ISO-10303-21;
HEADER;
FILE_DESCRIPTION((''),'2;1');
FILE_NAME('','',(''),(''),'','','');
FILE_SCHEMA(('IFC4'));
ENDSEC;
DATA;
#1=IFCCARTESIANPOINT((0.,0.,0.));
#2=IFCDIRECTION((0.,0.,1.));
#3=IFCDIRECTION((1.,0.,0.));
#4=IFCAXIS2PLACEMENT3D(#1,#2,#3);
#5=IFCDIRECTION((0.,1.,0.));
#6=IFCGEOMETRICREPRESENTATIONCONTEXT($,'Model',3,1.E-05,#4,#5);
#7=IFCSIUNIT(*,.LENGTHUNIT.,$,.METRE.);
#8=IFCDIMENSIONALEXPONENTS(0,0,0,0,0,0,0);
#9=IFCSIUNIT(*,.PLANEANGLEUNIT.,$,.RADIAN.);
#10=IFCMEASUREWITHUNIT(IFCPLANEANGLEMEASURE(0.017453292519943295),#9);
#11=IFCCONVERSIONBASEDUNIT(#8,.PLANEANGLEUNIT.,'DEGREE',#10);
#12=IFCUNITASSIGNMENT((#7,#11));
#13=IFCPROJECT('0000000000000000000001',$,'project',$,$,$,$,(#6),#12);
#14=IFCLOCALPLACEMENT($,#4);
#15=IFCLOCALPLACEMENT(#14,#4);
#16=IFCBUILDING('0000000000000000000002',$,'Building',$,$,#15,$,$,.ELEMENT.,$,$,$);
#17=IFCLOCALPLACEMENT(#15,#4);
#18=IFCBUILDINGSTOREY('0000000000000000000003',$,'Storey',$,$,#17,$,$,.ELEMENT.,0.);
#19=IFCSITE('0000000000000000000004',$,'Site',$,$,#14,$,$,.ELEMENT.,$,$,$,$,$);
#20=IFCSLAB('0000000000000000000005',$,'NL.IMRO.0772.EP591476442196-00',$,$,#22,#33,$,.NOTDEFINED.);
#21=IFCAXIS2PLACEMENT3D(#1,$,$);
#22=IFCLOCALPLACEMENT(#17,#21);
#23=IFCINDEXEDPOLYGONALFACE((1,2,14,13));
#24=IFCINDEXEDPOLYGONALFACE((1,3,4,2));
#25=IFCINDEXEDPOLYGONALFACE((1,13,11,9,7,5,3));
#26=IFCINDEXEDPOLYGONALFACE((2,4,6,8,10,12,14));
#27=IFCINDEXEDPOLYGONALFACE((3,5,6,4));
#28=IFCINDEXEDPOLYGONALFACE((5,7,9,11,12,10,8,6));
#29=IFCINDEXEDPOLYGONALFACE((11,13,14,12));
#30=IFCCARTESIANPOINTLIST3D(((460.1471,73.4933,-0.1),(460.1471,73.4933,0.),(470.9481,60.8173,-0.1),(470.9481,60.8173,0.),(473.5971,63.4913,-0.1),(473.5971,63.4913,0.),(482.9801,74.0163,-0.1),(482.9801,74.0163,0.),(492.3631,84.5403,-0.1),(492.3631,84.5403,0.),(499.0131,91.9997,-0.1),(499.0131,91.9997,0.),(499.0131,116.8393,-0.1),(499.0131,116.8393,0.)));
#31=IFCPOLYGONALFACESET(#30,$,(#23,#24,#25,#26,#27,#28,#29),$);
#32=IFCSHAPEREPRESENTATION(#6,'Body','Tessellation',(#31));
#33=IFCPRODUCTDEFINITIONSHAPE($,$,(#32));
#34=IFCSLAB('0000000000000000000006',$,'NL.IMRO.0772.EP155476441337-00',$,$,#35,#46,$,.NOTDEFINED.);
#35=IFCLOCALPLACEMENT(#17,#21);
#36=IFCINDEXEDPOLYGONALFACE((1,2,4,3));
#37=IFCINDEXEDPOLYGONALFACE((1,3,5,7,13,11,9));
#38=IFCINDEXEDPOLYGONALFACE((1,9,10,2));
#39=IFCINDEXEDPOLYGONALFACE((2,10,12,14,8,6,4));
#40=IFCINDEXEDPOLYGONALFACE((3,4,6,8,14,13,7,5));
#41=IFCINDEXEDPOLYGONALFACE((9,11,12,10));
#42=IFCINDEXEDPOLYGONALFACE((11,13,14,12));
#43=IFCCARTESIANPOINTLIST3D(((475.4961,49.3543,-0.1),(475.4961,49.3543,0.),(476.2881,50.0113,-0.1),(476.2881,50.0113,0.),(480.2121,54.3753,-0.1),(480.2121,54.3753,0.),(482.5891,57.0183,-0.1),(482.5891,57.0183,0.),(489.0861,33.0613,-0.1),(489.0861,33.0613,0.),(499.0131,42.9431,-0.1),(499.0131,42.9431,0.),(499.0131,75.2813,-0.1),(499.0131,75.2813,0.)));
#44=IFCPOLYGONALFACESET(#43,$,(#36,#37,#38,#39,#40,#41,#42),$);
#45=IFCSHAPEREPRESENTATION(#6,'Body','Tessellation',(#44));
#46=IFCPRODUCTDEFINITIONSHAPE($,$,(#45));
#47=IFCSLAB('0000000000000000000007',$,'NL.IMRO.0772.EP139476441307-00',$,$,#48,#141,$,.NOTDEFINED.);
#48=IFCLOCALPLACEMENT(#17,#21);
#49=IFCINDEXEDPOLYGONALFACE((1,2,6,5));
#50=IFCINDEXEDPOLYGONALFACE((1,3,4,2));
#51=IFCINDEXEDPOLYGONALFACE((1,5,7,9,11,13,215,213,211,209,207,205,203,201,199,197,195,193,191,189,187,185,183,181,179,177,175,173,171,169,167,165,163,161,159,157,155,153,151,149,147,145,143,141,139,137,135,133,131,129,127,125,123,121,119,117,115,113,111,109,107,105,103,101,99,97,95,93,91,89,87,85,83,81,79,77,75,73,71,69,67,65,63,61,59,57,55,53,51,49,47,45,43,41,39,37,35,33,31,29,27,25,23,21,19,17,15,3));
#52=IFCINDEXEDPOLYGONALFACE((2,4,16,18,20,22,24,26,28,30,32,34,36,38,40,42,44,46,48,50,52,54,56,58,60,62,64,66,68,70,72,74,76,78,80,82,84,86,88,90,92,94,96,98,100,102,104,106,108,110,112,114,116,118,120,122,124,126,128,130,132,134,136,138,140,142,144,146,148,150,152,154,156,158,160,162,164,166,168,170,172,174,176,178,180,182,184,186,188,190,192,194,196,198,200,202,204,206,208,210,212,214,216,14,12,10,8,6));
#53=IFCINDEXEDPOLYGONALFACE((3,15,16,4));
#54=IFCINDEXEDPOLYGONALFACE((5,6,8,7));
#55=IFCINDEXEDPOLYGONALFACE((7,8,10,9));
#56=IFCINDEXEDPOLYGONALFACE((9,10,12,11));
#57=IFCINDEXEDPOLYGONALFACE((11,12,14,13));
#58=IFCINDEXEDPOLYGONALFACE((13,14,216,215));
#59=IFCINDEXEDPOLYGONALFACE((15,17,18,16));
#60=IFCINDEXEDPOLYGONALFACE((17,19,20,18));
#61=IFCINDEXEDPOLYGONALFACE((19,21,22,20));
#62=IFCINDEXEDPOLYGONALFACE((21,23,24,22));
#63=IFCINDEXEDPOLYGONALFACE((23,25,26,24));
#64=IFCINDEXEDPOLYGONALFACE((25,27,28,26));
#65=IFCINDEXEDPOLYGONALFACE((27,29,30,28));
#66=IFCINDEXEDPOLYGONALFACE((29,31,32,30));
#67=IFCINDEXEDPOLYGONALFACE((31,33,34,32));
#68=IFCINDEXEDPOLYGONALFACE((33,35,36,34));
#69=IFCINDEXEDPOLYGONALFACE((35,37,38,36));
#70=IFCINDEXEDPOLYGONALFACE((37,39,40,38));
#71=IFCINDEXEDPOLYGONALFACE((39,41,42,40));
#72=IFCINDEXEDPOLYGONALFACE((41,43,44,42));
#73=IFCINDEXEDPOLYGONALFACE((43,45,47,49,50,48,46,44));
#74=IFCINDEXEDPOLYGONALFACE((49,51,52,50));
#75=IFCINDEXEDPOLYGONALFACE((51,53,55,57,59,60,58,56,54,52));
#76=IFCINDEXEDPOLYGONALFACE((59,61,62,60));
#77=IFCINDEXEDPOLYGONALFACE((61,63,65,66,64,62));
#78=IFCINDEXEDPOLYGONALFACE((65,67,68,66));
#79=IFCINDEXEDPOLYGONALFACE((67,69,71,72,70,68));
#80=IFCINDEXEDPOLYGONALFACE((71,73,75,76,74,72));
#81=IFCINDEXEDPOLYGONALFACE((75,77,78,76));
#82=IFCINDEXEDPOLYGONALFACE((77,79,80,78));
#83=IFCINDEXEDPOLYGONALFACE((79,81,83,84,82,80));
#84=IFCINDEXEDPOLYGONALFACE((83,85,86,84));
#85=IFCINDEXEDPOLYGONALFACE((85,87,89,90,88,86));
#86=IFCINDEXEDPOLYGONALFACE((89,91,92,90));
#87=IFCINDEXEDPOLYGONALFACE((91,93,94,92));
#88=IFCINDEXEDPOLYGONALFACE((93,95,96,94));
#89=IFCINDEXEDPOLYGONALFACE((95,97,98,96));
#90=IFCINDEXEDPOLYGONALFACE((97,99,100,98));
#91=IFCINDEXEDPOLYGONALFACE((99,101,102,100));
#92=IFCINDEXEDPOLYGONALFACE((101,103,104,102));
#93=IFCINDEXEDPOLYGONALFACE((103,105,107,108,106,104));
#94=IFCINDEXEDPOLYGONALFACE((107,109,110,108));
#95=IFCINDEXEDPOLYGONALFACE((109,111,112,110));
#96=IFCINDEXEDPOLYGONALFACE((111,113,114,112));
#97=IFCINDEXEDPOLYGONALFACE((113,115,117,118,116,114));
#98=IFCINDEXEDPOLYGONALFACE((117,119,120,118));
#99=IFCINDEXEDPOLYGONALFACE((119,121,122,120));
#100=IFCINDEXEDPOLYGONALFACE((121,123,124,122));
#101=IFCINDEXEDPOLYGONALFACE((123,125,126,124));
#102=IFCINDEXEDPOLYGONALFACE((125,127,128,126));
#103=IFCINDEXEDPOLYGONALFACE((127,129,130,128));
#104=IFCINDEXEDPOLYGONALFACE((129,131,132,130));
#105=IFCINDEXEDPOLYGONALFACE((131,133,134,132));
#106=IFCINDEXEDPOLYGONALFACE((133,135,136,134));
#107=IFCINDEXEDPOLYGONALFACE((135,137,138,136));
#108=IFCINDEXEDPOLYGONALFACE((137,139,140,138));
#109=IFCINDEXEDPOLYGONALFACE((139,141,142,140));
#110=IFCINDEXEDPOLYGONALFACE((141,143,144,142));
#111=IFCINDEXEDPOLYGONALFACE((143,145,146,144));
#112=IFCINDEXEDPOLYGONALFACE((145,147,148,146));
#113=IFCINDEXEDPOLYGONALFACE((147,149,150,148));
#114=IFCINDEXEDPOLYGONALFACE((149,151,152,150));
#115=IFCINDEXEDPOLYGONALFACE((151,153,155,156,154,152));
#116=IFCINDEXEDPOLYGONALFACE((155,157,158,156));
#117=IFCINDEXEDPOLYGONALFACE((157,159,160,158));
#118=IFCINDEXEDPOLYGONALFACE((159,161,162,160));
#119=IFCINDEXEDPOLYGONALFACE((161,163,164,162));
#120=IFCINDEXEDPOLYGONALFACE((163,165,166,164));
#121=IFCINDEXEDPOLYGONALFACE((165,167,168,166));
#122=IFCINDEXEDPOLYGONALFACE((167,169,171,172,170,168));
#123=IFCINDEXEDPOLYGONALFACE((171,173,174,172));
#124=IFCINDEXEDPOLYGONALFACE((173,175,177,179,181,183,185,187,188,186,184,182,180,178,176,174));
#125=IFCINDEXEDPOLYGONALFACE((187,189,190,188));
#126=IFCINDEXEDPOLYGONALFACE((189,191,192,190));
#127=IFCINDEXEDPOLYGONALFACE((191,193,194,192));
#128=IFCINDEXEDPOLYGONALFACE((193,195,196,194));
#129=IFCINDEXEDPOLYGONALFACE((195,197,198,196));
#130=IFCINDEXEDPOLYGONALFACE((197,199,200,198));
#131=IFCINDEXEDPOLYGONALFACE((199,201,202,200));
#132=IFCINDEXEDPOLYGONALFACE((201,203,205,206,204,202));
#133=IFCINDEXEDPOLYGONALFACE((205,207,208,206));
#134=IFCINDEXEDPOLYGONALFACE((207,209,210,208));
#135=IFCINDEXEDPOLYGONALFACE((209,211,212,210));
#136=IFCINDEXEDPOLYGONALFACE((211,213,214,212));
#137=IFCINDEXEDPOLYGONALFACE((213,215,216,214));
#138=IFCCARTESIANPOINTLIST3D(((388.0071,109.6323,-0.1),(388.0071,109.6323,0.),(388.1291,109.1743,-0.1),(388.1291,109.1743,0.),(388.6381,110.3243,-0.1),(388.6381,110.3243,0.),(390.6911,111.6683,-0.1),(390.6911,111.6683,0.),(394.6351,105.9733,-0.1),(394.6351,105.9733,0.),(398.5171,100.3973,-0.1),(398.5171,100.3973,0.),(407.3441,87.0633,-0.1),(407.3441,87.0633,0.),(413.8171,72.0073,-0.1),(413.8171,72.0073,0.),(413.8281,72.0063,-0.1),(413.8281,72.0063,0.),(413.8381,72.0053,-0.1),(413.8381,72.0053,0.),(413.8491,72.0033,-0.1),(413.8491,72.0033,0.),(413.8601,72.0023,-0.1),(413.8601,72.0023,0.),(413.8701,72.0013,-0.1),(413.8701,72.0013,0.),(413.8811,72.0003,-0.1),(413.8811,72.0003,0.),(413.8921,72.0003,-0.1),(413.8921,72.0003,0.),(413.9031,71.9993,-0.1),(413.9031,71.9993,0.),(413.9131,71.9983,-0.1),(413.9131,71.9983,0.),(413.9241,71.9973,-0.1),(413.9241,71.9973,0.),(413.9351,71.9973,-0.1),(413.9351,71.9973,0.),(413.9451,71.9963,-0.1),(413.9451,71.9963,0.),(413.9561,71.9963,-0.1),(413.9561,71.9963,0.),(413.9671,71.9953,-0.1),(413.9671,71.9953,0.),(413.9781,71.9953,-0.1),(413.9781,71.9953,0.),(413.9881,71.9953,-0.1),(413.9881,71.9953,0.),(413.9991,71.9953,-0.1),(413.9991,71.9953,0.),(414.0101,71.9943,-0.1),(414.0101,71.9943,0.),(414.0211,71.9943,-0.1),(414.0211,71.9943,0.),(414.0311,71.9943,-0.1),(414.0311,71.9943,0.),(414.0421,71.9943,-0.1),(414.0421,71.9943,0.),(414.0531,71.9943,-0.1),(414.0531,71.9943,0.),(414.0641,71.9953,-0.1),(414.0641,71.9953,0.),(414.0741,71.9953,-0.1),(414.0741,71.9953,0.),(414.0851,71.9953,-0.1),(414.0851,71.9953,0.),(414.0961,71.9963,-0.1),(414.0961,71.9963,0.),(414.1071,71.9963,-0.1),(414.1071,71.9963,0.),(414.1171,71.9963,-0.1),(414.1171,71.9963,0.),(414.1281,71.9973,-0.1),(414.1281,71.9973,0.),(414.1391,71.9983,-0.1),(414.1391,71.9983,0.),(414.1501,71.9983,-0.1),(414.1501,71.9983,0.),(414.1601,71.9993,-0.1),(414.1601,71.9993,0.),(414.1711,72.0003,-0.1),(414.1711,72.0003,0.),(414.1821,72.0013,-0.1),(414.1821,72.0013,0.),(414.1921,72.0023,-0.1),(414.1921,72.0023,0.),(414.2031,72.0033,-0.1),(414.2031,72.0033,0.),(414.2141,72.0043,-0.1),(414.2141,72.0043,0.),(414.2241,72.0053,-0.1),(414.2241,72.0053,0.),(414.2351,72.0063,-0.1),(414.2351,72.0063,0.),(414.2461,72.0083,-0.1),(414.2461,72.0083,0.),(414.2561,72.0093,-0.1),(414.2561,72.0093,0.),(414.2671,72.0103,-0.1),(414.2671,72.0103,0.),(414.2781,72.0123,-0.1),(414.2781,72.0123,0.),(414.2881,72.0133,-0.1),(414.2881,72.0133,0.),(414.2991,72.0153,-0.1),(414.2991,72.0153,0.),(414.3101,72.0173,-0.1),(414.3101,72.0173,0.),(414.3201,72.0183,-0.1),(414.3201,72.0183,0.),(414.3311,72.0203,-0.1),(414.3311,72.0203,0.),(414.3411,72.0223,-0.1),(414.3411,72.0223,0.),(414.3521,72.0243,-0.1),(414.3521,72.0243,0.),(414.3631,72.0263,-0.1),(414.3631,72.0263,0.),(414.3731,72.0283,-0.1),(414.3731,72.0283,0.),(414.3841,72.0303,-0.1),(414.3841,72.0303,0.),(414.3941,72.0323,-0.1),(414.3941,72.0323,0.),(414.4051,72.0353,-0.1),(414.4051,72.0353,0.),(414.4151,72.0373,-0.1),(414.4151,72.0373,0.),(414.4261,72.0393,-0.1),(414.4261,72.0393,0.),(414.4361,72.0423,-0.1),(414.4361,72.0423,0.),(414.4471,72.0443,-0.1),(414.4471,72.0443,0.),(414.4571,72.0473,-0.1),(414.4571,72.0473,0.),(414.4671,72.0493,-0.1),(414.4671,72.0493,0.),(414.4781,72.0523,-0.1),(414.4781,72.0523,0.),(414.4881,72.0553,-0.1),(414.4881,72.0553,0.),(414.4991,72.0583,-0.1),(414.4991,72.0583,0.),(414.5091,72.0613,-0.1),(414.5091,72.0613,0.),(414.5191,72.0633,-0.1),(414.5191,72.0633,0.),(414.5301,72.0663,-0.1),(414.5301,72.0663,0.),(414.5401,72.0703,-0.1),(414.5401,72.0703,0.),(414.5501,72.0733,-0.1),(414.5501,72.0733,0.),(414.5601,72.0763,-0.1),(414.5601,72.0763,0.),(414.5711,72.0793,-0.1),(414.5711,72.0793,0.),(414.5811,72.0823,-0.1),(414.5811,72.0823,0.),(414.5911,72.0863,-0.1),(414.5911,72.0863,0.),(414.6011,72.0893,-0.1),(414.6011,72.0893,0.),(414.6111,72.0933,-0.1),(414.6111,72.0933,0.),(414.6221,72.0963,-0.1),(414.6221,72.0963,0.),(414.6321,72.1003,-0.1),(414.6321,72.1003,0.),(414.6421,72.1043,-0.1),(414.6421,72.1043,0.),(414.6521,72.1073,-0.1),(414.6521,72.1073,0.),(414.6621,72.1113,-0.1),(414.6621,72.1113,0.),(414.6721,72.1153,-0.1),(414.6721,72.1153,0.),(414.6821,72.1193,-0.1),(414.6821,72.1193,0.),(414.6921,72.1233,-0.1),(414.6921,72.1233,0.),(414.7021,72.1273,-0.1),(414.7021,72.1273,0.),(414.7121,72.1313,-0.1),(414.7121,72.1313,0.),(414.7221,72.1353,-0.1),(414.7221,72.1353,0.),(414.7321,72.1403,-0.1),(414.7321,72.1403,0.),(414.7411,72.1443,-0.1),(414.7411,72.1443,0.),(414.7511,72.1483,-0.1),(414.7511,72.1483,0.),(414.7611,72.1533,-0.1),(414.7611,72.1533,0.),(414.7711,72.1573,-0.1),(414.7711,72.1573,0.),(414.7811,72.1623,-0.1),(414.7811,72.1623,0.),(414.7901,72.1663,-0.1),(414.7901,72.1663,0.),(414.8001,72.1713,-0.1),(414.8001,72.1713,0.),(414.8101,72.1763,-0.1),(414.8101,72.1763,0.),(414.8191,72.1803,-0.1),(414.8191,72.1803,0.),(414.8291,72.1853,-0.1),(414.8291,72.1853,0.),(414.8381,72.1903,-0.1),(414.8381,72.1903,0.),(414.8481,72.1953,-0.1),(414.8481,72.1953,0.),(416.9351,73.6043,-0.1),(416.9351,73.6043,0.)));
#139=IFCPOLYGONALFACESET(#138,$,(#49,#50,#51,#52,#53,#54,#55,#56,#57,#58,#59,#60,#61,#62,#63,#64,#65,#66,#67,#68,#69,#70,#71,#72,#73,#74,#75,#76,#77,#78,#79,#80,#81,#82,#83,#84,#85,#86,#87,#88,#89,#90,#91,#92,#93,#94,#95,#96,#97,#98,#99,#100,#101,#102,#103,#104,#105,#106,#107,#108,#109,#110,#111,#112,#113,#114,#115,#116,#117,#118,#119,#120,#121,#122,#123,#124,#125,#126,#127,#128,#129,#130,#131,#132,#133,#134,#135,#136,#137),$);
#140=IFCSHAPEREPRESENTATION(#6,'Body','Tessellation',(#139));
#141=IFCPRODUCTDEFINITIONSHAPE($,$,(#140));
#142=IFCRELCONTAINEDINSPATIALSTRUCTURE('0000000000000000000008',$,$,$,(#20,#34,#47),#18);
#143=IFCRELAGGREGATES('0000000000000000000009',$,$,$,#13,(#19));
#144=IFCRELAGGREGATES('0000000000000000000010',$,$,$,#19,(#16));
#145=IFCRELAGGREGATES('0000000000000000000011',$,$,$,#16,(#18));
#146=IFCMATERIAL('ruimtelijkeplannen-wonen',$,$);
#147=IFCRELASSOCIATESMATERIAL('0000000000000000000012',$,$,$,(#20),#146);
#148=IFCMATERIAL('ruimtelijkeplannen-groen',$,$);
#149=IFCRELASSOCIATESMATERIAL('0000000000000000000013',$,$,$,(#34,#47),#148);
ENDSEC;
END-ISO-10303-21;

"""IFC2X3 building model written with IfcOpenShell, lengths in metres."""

from ifc_helpers import new_model, entity, si_unit, converted_unit, direction, frame, origin_with_axes, place, context, project, spatial, polyline, outline, extrude, material, element, save


model = new_model("IFC2X3")

# Units and contexts
model_context = context("Model", 3, precision=1e-05, world=origin_with_axes(), true_north=direction((0.0, 1.0, 0.0)))
ifc_project = project(units=[si_unit("LENGTHUNIT", "METRE"), converted_unit("PLANEANGLEUNIT", "DEGREE", entity("IfcPlaneAngleMeasure", 0.017453292519943295), si_unit("PLANEANGLEUNIT", "RADIAN"), dimensions=[0, 0, 0, 0, 0, 0, 0])], contexts=[model_context])

# Site, building, storey
site_placement = place(None, origin_with_axes())
site = spatial("IfcSite", under=ifc_project, at=site_placement, Name="Site", CompositionType="ELEMENT")
building_placement = place(site_placement, origin_with_axes())
building = spatial("IfcBuilding", under=site, at=building_placement, Name="Building", CompositionType="ELEMENT")
storey_placement = place(building_placement, origin_with_axes())
storey = spatial("IfcBuildingStorey", under=building, at=storey_placement, Name="Storey", CompositionType="ELEMENT", Elevation=0.0)

# Slabs
ifc_material_1 = material(Name="ruimtelijkeplannen-wonen")
ifc_material_2 = material(Name="ruimtelijkeplannen-groen")
slab_1_placement = place(storey_placement, frame((0.0, 0.0, -0.1), z_axis=(0.0, 0.0, 1.0), x_axis=(1.0, 0.0, 0.0)))
element("IfcSlab", 1, at=slab_1_placement, inside=storey, material=ifc_material_1, Name="NL.IMRO.0772.EP591476442196-00", PredefinedType="NOTDEFINED", context=model_context, shape_type="SweptSolid", body=[
    extrude(outline(polyline([(492.3631, 84.5403), (482.9801, 74.0163), (473.5971, 63.4913), (470.9481, 60.8173), (460.1471, 73.4933), (499.0131, 116.8393), (499.0131, 91.9997), (492.3631, 84.5403)])), origin_with_axes(), (0.0, 0.0, 1.0), 0.1),
])
slab_2_placement = place(storey_placement, frame((0.0, 0.0, -0.1), z_axis=(0.0, 0.0, 1.0), x_axis=(1.0, 0.0, 0.0)))
element("IfcSlab", 2, at=slab_2_placement, inside=storey, material=ifc_material_2, Name="NL.IMRO.0772.EP155476441337-00", PredefinedType="NOTDEFINED", context=model_context, shape_type="SweptSolid", body=[
    extrude(outline(polyline([(489.0861, 33.0613), (475.4961, 49.3543), (476.2881, 50.0113), (480.2121, 54.3753), (482.5891, 57.0183), (499.0131, 75.2813), (499.0131, 42.9431), (489.0861, 33.0613)])), origin_with_axes(), (0.0, 0.0, 1.0), 0.1),
])
slab_3_placement = place(storey_placement, frame((0.0, 0.0, -0.1), z_axis=(0.0, 0.0, 1.0), x_axis=(1.0, 0.0, 0.0)))
element("IfcSlab", 3, at=slab_3_placement, inside=storey, material=ifc_material_2, Name="NL.IMRO.0772.EP139476441307-00", PredefinedType="NOTDEFINED", context=model_context, shape_type="SweptSolid", body=[
    extrude(outline(polyline([(388.1291, 109.1743), (388.0071, 109.6323), (388.6381, 110.3243), (390.6911, 111.6683), (394.6351, 105.9733), (398.5171, 100.3973), (407.3441, 87.0633), (416.9351, 73.6043), (414.8481, 72.1953), (414.8381, 72.1903), (414.8291, 72.1853), (414.8191, 72.1803), (414.8101, 72.1763), (414.8001, 72.1713), (414.7901, 72.1663), (414.7811, 72.1623), (414.7711, 72.1573), (414.7611, 72.1533), (414.7511, 72.1483), (414.7411, 72.1443), (414.7321, 72.1403), (414.7221, 72.1353), (414.7121, 72.1313), (414.7021, 72.1273), (414.6921, 72.1233), (414.6821, 72.1193), (414.6721, 72.1153), (414.6621, 72.1113), (414.6521, 72.1073), (414.6421, 72.1043), (414.6321, 72.1003), (414.6221, 72.0963), (414.6111, 72.0933), (414.6011, 72.0893), (414.5911, 72.0863), (414.5811, 72.0823), (414.5711, 72.0793), (414.5601, 72.0763), (414.5501, 72.0733), (414.5401, 72.0703), (414.5301, 72.0663), (414.5191, 72.0633), (414.5091, 72.0613), (414.4991, 72.0583), (414.4881, 72.0553), (414.4781, 72.0523), (414.4671, 72.0493), (414.4571, 72.0473), (414.4471, 72.0443), (414.4361, 72.0423), (414.4261, 72.0393), (414.4151, 72.0373), (414.4051, 72.0353), (414.3941, 72.0323), (414.3841, 72.0303), (414.3731, 72.0283), (414.3631, 72.0263), (414.3521, 72.0243), (414.3411, 72.0223), (414.3311, 72.0203), (414.3201, 72.0183), (414.3101, 72.0173), (414.2991, 72.0153), (414.2881, 72.0133), (414.2781, 72.0123), (414.2671, 72.0103), (414.2561, 72.0093), (414.2461, 72.0083), (414.2351, 72.0063), (414.2241, 72.0053), (414.2141, 72.0043), (414.2031, 72.0033), (414.1921, 72.0023), (414.1821, 72.0013), (414.1711, 72.0003), (414.1601, 71.9993), (414.1501, 71.9983), (414.1391, 71.9983), (414.1281, 71.9973), (414.1171, 71.9963), (414.1071, 71.9963), (414.0961, 71.9963), (414.0851, 71.9953), (414.0741, 71.9953), (414.0641, 71.9953), (414.0531, 71.9943), (414.0421, 71.9943), (414.0311, 71.9943), (414.0211, 71.9943), (414.0101, 71.9943), (413.9991, 71.9953), (413.9881, 71.9953), (413.9781, 71.9953), (413.9671, 71.9953), (413.9561, 71.9963), (413.9451, 71.9963), (413.9351, 71.9973), (413.9241, 71.9973), (413.9131, 71.9983), (413.9031, 71.9993), (413.8921, 72.0003), (413.8811, 72.0003), (413.8701, 72.0013), (413.8601, 72.0023), (413.8491, 72.0033), (413.8381, 72.0053), (413.8281, 72.0063), (413.8171, 72.0073), (388.1291, 109.1743)])), origin_with_axes(), (0.0, 0.0, 1.0), 0.1),
])

save(model, "model.ifc")
